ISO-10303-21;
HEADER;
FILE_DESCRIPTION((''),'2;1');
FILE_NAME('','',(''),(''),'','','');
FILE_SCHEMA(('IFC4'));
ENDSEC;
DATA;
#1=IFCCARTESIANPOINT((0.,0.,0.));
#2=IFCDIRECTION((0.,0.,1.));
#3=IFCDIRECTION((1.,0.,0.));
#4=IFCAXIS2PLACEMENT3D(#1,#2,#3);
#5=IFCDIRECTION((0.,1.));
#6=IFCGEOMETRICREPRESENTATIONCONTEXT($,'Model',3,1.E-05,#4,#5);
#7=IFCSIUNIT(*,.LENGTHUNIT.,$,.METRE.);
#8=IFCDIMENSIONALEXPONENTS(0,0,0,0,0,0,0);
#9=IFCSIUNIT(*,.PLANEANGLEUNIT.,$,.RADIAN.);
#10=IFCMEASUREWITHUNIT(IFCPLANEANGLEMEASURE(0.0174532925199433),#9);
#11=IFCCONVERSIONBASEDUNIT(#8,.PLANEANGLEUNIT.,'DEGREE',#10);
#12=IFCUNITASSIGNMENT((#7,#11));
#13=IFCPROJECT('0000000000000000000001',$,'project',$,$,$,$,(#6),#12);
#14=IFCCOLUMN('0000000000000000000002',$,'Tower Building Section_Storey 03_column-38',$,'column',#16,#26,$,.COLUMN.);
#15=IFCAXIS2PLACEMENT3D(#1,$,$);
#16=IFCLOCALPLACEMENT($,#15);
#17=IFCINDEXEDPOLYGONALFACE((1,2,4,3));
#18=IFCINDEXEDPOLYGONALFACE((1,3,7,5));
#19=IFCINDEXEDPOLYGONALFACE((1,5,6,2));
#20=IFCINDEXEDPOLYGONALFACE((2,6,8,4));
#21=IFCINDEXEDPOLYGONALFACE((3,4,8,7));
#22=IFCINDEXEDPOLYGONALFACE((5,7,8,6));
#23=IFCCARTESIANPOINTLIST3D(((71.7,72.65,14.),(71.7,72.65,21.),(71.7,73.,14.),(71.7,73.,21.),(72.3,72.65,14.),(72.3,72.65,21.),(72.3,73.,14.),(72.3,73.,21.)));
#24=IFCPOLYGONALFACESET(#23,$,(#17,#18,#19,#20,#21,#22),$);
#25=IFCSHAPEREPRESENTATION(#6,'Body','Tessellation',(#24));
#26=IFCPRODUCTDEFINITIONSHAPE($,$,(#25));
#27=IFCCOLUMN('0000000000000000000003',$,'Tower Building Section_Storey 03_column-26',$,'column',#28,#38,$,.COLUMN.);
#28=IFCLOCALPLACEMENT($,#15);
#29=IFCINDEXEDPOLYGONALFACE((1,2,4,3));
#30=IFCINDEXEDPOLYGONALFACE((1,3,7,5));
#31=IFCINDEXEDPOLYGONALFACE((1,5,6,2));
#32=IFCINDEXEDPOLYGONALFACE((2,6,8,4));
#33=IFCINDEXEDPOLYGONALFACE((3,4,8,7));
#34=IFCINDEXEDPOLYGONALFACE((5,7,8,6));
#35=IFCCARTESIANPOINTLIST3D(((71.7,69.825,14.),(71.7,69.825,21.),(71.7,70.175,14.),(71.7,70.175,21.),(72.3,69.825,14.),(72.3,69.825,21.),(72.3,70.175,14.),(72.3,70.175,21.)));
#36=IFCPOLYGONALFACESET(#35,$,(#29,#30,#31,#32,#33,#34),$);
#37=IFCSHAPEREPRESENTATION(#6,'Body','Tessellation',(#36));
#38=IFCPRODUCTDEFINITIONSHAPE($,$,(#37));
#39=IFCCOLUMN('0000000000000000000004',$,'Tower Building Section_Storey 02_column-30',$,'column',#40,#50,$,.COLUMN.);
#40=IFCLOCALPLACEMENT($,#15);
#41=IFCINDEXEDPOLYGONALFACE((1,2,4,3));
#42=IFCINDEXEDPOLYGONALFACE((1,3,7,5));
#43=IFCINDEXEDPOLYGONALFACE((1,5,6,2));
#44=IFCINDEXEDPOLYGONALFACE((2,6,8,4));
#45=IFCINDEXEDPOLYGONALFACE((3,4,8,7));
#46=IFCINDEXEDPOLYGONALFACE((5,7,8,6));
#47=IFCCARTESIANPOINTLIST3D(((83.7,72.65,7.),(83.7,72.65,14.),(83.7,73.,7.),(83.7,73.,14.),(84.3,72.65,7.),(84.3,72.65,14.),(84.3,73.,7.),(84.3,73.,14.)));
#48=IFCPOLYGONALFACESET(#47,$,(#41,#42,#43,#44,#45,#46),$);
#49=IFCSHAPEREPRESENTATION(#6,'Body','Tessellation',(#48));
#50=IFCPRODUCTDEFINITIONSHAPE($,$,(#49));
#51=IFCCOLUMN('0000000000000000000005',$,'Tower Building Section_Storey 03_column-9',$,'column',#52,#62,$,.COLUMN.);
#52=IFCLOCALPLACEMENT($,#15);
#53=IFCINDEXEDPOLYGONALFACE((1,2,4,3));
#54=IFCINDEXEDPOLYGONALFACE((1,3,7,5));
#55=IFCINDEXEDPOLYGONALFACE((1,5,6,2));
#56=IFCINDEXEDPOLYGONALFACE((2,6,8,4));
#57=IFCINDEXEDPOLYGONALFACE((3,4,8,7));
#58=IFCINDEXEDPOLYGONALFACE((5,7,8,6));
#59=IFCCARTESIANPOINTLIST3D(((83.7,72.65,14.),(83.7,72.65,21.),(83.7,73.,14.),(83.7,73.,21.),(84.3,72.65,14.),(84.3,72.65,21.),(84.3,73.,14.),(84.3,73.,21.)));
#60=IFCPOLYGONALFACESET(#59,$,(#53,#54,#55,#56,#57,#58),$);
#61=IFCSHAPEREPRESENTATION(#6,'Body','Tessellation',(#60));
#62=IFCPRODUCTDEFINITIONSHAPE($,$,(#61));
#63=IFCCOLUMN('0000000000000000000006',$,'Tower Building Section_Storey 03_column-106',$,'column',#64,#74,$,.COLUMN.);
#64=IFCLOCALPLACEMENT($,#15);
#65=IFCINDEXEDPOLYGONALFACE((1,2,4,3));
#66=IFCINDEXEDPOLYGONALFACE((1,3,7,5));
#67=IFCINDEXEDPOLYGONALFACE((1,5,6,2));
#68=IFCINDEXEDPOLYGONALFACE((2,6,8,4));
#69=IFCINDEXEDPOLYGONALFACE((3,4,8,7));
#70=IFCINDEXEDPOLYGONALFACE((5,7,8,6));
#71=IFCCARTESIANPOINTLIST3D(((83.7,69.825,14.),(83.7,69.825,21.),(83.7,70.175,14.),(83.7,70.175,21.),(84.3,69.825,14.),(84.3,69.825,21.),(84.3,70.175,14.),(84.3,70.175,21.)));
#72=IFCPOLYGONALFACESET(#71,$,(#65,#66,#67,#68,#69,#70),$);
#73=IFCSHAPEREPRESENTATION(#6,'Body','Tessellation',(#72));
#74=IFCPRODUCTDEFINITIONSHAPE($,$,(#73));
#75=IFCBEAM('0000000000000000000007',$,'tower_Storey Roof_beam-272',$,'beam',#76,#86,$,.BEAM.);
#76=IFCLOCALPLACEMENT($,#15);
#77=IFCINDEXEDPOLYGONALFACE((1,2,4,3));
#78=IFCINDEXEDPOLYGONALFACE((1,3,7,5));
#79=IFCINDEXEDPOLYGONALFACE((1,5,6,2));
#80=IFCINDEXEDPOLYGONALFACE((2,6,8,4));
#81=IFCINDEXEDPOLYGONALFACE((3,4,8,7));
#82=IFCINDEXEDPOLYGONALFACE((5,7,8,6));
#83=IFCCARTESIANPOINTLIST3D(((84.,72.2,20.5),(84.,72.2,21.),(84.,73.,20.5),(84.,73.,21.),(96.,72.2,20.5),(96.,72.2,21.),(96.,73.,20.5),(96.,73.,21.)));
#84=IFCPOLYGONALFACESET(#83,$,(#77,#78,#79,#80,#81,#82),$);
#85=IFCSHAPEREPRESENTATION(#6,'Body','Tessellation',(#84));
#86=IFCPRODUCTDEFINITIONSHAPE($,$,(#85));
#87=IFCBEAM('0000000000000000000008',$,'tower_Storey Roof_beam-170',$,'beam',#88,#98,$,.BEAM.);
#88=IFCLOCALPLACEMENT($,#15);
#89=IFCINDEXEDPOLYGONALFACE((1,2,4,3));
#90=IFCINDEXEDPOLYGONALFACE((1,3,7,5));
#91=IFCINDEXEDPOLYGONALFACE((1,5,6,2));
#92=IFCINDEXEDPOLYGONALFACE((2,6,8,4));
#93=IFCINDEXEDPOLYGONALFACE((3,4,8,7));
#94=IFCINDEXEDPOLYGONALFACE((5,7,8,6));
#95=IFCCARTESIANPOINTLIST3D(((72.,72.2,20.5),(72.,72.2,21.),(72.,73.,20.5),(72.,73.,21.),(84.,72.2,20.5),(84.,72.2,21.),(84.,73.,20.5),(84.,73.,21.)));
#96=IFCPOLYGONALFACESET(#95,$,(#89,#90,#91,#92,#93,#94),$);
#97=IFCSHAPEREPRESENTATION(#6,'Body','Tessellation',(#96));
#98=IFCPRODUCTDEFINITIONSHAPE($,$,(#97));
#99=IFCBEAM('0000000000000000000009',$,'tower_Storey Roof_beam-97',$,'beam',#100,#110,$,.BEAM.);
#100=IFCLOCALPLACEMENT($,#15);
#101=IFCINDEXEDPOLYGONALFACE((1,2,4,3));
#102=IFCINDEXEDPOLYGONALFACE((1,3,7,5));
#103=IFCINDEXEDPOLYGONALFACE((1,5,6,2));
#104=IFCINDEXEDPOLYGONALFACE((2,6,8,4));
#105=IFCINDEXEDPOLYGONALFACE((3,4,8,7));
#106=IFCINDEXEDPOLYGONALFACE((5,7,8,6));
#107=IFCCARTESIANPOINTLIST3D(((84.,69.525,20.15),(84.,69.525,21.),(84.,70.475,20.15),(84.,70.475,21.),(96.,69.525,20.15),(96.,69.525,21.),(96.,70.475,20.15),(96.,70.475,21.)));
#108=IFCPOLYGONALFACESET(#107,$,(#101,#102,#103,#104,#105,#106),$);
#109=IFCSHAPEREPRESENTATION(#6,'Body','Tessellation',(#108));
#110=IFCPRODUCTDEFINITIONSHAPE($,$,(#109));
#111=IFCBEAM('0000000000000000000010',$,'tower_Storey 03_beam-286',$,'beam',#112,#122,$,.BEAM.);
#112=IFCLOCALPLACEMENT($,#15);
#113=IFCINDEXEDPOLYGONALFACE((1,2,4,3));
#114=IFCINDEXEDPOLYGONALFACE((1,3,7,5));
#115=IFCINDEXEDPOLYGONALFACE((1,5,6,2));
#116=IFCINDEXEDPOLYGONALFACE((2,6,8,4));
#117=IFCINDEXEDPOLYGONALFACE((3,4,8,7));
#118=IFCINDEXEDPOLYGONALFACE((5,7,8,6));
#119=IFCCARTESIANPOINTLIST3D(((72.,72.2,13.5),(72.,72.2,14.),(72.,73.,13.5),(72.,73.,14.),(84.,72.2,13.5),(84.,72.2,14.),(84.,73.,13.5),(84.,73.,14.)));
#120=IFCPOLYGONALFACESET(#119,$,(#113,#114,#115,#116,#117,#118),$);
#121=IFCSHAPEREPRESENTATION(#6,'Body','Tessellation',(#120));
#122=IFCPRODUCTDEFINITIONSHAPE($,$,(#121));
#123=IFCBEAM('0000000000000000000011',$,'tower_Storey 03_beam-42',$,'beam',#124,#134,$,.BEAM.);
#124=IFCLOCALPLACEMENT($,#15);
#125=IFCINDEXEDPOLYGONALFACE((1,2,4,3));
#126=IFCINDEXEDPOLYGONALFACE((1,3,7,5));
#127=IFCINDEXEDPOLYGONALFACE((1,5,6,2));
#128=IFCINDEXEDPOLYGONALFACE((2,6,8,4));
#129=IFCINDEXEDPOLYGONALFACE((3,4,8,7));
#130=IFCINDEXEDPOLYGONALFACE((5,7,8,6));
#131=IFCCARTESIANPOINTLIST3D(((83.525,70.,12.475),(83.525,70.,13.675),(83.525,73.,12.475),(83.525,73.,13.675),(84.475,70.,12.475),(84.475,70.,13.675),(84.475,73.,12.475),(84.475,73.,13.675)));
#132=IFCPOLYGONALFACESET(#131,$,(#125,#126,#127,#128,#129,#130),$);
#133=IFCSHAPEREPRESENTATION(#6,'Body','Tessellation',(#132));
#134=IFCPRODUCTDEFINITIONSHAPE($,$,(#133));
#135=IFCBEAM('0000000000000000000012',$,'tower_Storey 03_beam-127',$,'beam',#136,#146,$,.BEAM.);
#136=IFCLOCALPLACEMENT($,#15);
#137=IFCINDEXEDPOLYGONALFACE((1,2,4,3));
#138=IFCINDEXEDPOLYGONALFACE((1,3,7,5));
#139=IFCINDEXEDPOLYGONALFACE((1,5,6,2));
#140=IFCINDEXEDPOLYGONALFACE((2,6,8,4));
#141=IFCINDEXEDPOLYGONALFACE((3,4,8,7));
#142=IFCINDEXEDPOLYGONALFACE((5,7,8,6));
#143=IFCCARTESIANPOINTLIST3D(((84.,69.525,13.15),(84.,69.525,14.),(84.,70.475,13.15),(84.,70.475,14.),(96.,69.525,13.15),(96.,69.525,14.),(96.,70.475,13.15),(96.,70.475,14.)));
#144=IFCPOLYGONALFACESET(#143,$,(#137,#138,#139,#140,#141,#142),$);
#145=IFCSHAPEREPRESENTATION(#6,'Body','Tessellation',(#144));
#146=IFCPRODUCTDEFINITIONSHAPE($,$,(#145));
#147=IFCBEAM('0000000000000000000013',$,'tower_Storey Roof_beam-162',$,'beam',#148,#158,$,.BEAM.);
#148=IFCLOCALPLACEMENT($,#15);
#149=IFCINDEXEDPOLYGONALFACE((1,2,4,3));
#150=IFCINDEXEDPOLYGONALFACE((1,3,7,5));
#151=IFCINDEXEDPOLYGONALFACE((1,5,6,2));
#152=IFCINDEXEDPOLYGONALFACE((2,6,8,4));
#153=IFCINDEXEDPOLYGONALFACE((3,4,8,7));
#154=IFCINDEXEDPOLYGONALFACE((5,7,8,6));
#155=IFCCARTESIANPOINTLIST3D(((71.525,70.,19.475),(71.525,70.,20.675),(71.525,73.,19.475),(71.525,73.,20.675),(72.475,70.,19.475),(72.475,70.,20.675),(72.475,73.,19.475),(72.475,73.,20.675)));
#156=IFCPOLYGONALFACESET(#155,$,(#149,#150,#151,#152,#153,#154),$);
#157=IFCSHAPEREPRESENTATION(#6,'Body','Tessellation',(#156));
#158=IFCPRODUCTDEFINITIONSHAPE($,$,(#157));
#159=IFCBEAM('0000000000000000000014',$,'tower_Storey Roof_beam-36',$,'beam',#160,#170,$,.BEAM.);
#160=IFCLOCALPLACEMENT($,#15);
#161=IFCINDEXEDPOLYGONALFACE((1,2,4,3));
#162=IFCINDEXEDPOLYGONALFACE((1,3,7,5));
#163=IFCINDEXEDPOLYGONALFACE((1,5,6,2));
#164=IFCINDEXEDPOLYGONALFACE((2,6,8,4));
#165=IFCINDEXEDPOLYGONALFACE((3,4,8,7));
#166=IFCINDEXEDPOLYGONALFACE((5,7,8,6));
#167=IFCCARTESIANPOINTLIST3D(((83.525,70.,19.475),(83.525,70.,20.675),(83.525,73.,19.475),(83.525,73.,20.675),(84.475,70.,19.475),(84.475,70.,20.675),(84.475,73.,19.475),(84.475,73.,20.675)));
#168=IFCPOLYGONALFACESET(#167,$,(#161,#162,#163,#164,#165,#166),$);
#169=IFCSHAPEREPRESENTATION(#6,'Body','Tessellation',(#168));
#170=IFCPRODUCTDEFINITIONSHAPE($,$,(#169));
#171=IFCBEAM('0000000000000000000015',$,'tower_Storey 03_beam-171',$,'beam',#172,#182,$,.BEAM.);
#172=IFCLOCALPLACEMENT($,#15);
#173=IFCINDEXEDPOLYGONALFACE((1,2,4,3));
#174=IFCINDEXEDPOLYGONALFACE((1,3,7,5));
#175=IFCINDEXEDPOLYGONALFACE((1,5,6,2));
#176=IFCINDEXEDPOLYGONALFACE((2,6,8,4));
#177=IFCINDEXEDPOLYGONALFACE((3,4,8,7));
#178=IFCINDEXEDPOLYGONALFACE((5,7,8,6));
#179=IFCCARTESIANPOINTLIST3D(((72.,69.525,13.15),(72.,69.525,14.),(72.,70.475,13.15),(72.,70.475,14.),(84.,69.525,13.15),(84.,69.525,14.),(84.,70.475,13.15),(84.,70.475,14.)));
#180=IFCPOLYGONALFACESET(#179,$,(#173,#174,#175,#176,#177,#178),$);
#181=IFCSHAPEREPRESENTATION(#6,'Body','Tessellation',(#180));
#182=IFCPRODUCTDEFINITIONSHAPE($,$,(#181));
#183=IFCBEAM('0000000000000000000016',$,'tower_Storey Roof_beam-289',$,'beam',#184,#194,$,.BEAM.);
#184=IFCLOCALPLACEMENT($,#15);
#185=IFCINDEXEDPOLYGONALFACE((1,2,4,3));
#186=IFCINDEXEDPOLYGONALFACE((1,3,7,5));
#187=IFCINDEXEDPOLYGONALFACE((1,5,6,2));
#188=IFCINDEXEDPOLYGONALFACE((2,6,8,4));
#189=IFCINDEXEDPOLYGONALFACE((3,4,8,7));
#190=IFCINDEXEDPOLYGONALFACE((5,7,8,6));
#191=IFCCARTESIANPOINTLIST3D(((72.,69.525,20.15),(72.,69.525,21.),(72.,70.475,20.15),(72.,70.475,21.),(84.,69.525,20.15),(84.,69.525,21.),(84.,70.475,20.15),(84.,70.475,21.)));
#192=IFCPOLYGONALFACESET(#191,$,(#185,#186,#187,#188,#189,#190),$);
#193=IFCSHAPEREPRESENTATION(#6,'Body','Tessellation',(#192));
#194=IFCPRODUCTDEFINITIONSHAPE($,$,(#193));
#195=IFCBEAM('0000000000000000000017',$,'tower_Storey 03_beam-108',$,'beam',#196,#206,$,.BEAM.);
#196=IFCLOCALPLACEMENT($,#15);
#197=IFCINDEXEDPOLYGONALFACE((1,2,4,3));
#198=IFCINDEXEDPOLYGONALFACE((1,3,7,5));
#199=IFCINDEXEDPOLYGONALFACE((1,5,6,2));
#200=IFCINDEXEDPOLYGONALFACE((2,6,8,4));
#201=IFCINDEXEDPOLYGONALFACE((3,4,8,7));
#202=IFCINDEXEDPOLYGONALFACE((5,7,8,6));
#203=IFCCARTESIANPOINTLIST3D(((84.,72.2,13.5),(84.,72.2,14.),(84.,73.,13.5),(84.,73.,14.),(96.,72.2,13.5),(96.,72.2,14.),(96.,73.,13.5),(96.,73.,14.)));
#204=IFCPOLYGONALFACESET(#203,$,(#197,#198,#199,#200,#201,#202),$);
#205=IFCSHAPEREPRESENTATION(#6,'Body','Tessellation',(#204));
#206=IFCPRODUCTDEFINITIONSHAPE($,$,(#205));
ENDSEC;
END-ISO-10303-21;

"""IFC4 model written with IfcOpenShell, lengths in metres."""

from ifc_helpers import new_model, entity, si_unit, converted_unit, direction, frame, origin_with_axes, place, context, project, polyline, outline, extrude, element, save


model = new_model("IFC4")

# Units and contexts
model_context = context("Model", 3, precision=1e-05, world=origin_with_axes(), true_north=direction((0.0, 1.0)))
ifc_project = project(units=[si_unit("LENGTHUNIT", "METRE"), converted_unit("PLANEANGLEUNIT", "DEGREE", entity("IfcPlaneAngleMeasure", 0.0174532925199433), si_unit("PLANEANGLEUNIT", "RADIAN"), dimensions=[0, 0, 0, 0, 0, 0, 0])], contexts=[model_context])

# Columns
placement_1 = place(None, origin_with_axes())
placement_2 = place(placement_1, frame((0.0, 0.0, 14.0), z_axis=(0.0, 0.0, 1.0), x_axis=(1.0, 0.0, 0.0)))
for number, where, z_axis, x_axis, name in (
    (1, (72.0, 72.825, 0.0), (0.0, 0.0, 1.0), (1.0, 0.0, 0.0), "Tower Building Section_Storey 03_column-38"),
    (2, (72.0, 70.0, 0.0), (0.0, 0.0, 1.0), (1.0, 0.0, 0.0), "Tower Building Section_Storey 03_column-26"),
):
    element("IfcColumn", number, at=place(placement_2, frame(where, z_axis=z_axis, x_axis=x_axis)), Name=name, ObjectType="column", PredefinedType="COLUMN", context=model_context, body=[
        extrude(outline(polyline([(-0.3, -0.175, 0.0), (0.3, -0.175, 0.0), (0.3, 0.175, 0.0), (-0.3, 0.175, 0.0), (-0.3, -0.175, 0.0)])), origin_with_axes(), (0.0, 0.0, 1.0), 7.0),
    ])
placement_3 = place(placement_1, frame((0.0, 0.0, 7.0), z_axis=(0.0, 0.0, 1.0), x_axis=(1.0, 0.0, 0.0)))
column_placement = place(placement_3, frame((84.0, 72.825, 0.0), z_axis=(0.0, 0.0, 1.0), x_axis=(1.0, 0.0, 0.0)))
element("IfcColumn", 3, at=column_placement, Name="Tower Building Section_Storey 02_column-30", ObjectType="column", PredefinedType="COLUMN", context=model_context, body=[
    extrude(outline(polyline([(-0.3, -0.175, 0.0), (0.3, -0.175, 0.0), (0.3, 0.175, 0.0), (-0.3, 0.175, 0.0), (-0.3, -0.175, 0.0)])), origin_with_axes(), (0.0, 0.0, 1.0), 7.0),
])
for number, where, z_axis, x_axis, name in (
    (4, (84.0, 72.825, 0.0), (0.0, 0.0, 1.0), (1.0, 0.0, 0.0), "Tower Building Section_Storey 03_column-9"),
    (5, (84.0, 70.0, 0.0), (0.0, 0.0, 1.0), (1.0, 0.0, 0.0), "Tower Building Section_Storey 03_column-106"),
):
    element("IfcColumn", number, at=place(placement_2, frame(where, z_axis=z_axis, x_axis=x_axis)), Name=name, ObjectType="column", PredefinedType="COLUMN", context=model_context, body=[
        extrude(outline(polyline([(-0.3, -0.175, 0.0), (0.3, -0.175, 0.0), (0.3, 0.175, 0.0), (-0.3, 0.175, 0.0), (-0.3, -0.175, 0.0)])), origin_with_axes(), (0.0, 0.0, 1.0), 7.0),
    ])

# Beams
placement_4 = place(placement_1, frame((0.0, 0.0, 21.0), z_axis=(0.0, 0.0, 1.0), x_axis=(1.0, 0.0, 0.0)))
for number, where, z_axis, x_axis, name in (
    (6, (84.0, 72.6, -0.25), (1.0, 0.0, 0.0), (0.0, 1.0, 0.0), "tower_Storey Roof_beam-272"),
    (7, (72.0, 72.6, -0.25), (1.0, 0.0, 0.0), (0.0, 1.0, 0.0), "tower_Storey Roof_beam-170"),
):
    element("IfcBeam", number, at=place(placement_4, frame(where, z_axis=z_axis, x_axis=x_axis)), Name=name, ObjectType="beam", PredefinedType="BEAM", context=model_context, body=[
        extrude(outline(polyline([(0.4, 0.25, 0.0), (-0.4, 0.25, 0.0), (-0.4, -0.25, 0.0), (0.4, -0.25, 0.0), (0.4, 0.25, 0.0)])), origin_with_axes(), (0.0, 0.0, 1.0), 12.0),
    ])
beam_1_placement = place(placement_4, frame((84.0, 70.0, -0.425), z_axis=(1.0, 0.0, 0.0), x_axis=(0.0, 1.0, 0.0)))
element("IfcBeam", 8, at=beam_1_placement, Name="tower_Storey Roof_beam-97", ObjectType="beam", PredefinedType="BEAM", context=model_context, body=[
    extrude(outline(polyline([(0.475, 0.425, 0.0), (-0.475, 0.425, 0.0), (-0.475, -0.425, 0.0), (0.475, -0.425, 0.0), (0.475, 0.425, 0.0)])), origin_with_axes(), (0.0, 0.0, 1.0), 12.0),
])
beam_2_placement = place(placement_2, frame((72.0, 72.6, -0.25), z_axis=(1.0, 0.0, 0.0), x_axis=(0.0, 1.0, 0.0)))
element("IfcBeam", 9, at=beam_2_placement, Name="tower_Storey 03_beam-286", ObjectType="beam", PredefinedType="BEAM", context=model_context, body=[
    extrude(outline(polyline([(0.4, 0.25, 0.0), (-0.4, 0.25, 0.0), (-0.4, -0.25, 0.0), (0.4, -0.25, 0.0), (0.4, 0.25, 0.0)])), origin_with_axes(), (0.0, 0.0, 1.0), 12.0),
])
beam_3_placement = place(placement_2, frame((84.0, 70.0, -0.925), z_axis=(0.0, 1.0, 0.0), x_axis=(-1.0, 0.0, 0.0)))
element("IfcBeam", 10, at=beam_3_placement, Name="tower_Storey 03_beam-42", ObjectType="beam", PredefinedType="BEAM", context=model_context, body=[
    extrude(outline(polyline([(0.475, 0.6, 0.0), (-0.475, 0.6, 0.0), (-0.475, -0.6, 0.0), (0.475, -0.6, 0.0), (0.475, 0.6, 0.0)])), origin_with_axes(), (0.0, 0.0, 1.0), 3.0),
])
beam_4_placement = place(placement_2, frame((84.0, 70.0, -0.425), z_axis=(1.0, 0.0, 0.0), x_axis=(0.0, 1.0, 0.0)))
element("IfcBeam", 11, at=beam_4_placement, Name="tower_Storey 03_beam-127", ObjectType="beam", PredefinedType="BEAM", context=model_context, body=[
    extrude(outline(polyline([(0.475, 0.425, 0.0), (-0.475, 0.425, 0.0), (-0.475, -0.425, 0.0), (0.475, -0.425, 0.0), (0.475, 0.425, 0.0)])), origin_with_axes(), (0.0, 0.0, 1.0), 12.0),
])
for number, where, z_axis, x_axis, name in (
    (12, (72.0, 70.0, -0.925), (0.0, 1.0, 0.0), (-1.0, 0.0, 0.0), "tower_Storey Roof_beam-162"),
    (13, (84.0, 70.0, -0.925), (0.0, 1.0, 0.0), (-1.0, 0.0, 0.0), "tower_Storey Roof_beam-36"),
):
    element("IfcBeam", number, at=place(placement_4, frame(where, z_axis=z_axis, x_axis=x_axis)), Name=name, ObjectType="beam", PredefinedType="BEAM", context=model_context, body=[
        extrude(outline(polyline([(0.475, 0.6, 0.0), (-0.475, 0.6, 0.0), (-0.475, -0.6, 0.0), (0.475, -0.6, 0.0), (0.475, 0.6, 0.0)])), origin_with_axes(), (0.0, 0.0, 1.0), 3.0),
    ])
beam_5_placement = place(placement_2, frame((72.0, 70.0, -0.425), z_axis=(1.0, 0.0, 0.0), x_axis=(0.0, 1.0, 0.0)))
element("IfcBeam", 14, at=beam_5_placement, Name="tower_Storey 03_beam-171", ObjectType="beam", PredefinedType="BEAM", context=model_context, body=[
    extrude(outline(polyline([(0.475, 0.425, 0.0), (-0.475, 0.425, 0.0), (-0.475, -0.425, 0.0), (0.475, -0.425, 0.0), (0.475, 0.425, 0.0)])), origin_with_axes(), (0.0, 0.0, 1.0), 12.0),
])
beam_6_placement = place(placement_4, frame((72.0, 70.0, -0.425), z_axis=(1.0, 0.0, 0.0), x_axis=(0.0, 1.0, 0.0)))
element("IfcBeam", 15, at=beam_6_placement, Name="tower_Storey Roof_beam-289", ObjectType="beam", PredefinedType="BEAM", context=model_context, body=[
    extrude(outline(polyline([(0.475, 0.425, 0.0), (-0.475, 0.425, 0.0), (-0.475, -0.425, 0.0), (0.475, -0.425, 0.0), (0.475, 0.425, 0.0)])), origin_with_axes(), (0.0, 0.0, 1.0), 12.0),
])
beam_7_placement = place(placement_2, frame((84.0, 72.6, -0.25), z_axis=(1.0, 0.0, 0.0), x_axis=(0.0, 1.0, 0.0)))
element("IfcBeam", 16, at=beam_7_placement, Name="tower_Storey 03_beam-108", ObjectType="beam", PredefinedType="BEAM", context=model_context, body=[
    extrude(outline(polyline([(0.4, 0.25, 0.0), (-0.4, 0.25, 0.0), (-0.4, -0.25, 0.0), (0.4, -0.25, 0.0), (0.4, 0.25, 0.0)])), origin_with_axes(), (0.0, 0.0, 1.0), 12.0),
])

save(model, "model.ifc")
